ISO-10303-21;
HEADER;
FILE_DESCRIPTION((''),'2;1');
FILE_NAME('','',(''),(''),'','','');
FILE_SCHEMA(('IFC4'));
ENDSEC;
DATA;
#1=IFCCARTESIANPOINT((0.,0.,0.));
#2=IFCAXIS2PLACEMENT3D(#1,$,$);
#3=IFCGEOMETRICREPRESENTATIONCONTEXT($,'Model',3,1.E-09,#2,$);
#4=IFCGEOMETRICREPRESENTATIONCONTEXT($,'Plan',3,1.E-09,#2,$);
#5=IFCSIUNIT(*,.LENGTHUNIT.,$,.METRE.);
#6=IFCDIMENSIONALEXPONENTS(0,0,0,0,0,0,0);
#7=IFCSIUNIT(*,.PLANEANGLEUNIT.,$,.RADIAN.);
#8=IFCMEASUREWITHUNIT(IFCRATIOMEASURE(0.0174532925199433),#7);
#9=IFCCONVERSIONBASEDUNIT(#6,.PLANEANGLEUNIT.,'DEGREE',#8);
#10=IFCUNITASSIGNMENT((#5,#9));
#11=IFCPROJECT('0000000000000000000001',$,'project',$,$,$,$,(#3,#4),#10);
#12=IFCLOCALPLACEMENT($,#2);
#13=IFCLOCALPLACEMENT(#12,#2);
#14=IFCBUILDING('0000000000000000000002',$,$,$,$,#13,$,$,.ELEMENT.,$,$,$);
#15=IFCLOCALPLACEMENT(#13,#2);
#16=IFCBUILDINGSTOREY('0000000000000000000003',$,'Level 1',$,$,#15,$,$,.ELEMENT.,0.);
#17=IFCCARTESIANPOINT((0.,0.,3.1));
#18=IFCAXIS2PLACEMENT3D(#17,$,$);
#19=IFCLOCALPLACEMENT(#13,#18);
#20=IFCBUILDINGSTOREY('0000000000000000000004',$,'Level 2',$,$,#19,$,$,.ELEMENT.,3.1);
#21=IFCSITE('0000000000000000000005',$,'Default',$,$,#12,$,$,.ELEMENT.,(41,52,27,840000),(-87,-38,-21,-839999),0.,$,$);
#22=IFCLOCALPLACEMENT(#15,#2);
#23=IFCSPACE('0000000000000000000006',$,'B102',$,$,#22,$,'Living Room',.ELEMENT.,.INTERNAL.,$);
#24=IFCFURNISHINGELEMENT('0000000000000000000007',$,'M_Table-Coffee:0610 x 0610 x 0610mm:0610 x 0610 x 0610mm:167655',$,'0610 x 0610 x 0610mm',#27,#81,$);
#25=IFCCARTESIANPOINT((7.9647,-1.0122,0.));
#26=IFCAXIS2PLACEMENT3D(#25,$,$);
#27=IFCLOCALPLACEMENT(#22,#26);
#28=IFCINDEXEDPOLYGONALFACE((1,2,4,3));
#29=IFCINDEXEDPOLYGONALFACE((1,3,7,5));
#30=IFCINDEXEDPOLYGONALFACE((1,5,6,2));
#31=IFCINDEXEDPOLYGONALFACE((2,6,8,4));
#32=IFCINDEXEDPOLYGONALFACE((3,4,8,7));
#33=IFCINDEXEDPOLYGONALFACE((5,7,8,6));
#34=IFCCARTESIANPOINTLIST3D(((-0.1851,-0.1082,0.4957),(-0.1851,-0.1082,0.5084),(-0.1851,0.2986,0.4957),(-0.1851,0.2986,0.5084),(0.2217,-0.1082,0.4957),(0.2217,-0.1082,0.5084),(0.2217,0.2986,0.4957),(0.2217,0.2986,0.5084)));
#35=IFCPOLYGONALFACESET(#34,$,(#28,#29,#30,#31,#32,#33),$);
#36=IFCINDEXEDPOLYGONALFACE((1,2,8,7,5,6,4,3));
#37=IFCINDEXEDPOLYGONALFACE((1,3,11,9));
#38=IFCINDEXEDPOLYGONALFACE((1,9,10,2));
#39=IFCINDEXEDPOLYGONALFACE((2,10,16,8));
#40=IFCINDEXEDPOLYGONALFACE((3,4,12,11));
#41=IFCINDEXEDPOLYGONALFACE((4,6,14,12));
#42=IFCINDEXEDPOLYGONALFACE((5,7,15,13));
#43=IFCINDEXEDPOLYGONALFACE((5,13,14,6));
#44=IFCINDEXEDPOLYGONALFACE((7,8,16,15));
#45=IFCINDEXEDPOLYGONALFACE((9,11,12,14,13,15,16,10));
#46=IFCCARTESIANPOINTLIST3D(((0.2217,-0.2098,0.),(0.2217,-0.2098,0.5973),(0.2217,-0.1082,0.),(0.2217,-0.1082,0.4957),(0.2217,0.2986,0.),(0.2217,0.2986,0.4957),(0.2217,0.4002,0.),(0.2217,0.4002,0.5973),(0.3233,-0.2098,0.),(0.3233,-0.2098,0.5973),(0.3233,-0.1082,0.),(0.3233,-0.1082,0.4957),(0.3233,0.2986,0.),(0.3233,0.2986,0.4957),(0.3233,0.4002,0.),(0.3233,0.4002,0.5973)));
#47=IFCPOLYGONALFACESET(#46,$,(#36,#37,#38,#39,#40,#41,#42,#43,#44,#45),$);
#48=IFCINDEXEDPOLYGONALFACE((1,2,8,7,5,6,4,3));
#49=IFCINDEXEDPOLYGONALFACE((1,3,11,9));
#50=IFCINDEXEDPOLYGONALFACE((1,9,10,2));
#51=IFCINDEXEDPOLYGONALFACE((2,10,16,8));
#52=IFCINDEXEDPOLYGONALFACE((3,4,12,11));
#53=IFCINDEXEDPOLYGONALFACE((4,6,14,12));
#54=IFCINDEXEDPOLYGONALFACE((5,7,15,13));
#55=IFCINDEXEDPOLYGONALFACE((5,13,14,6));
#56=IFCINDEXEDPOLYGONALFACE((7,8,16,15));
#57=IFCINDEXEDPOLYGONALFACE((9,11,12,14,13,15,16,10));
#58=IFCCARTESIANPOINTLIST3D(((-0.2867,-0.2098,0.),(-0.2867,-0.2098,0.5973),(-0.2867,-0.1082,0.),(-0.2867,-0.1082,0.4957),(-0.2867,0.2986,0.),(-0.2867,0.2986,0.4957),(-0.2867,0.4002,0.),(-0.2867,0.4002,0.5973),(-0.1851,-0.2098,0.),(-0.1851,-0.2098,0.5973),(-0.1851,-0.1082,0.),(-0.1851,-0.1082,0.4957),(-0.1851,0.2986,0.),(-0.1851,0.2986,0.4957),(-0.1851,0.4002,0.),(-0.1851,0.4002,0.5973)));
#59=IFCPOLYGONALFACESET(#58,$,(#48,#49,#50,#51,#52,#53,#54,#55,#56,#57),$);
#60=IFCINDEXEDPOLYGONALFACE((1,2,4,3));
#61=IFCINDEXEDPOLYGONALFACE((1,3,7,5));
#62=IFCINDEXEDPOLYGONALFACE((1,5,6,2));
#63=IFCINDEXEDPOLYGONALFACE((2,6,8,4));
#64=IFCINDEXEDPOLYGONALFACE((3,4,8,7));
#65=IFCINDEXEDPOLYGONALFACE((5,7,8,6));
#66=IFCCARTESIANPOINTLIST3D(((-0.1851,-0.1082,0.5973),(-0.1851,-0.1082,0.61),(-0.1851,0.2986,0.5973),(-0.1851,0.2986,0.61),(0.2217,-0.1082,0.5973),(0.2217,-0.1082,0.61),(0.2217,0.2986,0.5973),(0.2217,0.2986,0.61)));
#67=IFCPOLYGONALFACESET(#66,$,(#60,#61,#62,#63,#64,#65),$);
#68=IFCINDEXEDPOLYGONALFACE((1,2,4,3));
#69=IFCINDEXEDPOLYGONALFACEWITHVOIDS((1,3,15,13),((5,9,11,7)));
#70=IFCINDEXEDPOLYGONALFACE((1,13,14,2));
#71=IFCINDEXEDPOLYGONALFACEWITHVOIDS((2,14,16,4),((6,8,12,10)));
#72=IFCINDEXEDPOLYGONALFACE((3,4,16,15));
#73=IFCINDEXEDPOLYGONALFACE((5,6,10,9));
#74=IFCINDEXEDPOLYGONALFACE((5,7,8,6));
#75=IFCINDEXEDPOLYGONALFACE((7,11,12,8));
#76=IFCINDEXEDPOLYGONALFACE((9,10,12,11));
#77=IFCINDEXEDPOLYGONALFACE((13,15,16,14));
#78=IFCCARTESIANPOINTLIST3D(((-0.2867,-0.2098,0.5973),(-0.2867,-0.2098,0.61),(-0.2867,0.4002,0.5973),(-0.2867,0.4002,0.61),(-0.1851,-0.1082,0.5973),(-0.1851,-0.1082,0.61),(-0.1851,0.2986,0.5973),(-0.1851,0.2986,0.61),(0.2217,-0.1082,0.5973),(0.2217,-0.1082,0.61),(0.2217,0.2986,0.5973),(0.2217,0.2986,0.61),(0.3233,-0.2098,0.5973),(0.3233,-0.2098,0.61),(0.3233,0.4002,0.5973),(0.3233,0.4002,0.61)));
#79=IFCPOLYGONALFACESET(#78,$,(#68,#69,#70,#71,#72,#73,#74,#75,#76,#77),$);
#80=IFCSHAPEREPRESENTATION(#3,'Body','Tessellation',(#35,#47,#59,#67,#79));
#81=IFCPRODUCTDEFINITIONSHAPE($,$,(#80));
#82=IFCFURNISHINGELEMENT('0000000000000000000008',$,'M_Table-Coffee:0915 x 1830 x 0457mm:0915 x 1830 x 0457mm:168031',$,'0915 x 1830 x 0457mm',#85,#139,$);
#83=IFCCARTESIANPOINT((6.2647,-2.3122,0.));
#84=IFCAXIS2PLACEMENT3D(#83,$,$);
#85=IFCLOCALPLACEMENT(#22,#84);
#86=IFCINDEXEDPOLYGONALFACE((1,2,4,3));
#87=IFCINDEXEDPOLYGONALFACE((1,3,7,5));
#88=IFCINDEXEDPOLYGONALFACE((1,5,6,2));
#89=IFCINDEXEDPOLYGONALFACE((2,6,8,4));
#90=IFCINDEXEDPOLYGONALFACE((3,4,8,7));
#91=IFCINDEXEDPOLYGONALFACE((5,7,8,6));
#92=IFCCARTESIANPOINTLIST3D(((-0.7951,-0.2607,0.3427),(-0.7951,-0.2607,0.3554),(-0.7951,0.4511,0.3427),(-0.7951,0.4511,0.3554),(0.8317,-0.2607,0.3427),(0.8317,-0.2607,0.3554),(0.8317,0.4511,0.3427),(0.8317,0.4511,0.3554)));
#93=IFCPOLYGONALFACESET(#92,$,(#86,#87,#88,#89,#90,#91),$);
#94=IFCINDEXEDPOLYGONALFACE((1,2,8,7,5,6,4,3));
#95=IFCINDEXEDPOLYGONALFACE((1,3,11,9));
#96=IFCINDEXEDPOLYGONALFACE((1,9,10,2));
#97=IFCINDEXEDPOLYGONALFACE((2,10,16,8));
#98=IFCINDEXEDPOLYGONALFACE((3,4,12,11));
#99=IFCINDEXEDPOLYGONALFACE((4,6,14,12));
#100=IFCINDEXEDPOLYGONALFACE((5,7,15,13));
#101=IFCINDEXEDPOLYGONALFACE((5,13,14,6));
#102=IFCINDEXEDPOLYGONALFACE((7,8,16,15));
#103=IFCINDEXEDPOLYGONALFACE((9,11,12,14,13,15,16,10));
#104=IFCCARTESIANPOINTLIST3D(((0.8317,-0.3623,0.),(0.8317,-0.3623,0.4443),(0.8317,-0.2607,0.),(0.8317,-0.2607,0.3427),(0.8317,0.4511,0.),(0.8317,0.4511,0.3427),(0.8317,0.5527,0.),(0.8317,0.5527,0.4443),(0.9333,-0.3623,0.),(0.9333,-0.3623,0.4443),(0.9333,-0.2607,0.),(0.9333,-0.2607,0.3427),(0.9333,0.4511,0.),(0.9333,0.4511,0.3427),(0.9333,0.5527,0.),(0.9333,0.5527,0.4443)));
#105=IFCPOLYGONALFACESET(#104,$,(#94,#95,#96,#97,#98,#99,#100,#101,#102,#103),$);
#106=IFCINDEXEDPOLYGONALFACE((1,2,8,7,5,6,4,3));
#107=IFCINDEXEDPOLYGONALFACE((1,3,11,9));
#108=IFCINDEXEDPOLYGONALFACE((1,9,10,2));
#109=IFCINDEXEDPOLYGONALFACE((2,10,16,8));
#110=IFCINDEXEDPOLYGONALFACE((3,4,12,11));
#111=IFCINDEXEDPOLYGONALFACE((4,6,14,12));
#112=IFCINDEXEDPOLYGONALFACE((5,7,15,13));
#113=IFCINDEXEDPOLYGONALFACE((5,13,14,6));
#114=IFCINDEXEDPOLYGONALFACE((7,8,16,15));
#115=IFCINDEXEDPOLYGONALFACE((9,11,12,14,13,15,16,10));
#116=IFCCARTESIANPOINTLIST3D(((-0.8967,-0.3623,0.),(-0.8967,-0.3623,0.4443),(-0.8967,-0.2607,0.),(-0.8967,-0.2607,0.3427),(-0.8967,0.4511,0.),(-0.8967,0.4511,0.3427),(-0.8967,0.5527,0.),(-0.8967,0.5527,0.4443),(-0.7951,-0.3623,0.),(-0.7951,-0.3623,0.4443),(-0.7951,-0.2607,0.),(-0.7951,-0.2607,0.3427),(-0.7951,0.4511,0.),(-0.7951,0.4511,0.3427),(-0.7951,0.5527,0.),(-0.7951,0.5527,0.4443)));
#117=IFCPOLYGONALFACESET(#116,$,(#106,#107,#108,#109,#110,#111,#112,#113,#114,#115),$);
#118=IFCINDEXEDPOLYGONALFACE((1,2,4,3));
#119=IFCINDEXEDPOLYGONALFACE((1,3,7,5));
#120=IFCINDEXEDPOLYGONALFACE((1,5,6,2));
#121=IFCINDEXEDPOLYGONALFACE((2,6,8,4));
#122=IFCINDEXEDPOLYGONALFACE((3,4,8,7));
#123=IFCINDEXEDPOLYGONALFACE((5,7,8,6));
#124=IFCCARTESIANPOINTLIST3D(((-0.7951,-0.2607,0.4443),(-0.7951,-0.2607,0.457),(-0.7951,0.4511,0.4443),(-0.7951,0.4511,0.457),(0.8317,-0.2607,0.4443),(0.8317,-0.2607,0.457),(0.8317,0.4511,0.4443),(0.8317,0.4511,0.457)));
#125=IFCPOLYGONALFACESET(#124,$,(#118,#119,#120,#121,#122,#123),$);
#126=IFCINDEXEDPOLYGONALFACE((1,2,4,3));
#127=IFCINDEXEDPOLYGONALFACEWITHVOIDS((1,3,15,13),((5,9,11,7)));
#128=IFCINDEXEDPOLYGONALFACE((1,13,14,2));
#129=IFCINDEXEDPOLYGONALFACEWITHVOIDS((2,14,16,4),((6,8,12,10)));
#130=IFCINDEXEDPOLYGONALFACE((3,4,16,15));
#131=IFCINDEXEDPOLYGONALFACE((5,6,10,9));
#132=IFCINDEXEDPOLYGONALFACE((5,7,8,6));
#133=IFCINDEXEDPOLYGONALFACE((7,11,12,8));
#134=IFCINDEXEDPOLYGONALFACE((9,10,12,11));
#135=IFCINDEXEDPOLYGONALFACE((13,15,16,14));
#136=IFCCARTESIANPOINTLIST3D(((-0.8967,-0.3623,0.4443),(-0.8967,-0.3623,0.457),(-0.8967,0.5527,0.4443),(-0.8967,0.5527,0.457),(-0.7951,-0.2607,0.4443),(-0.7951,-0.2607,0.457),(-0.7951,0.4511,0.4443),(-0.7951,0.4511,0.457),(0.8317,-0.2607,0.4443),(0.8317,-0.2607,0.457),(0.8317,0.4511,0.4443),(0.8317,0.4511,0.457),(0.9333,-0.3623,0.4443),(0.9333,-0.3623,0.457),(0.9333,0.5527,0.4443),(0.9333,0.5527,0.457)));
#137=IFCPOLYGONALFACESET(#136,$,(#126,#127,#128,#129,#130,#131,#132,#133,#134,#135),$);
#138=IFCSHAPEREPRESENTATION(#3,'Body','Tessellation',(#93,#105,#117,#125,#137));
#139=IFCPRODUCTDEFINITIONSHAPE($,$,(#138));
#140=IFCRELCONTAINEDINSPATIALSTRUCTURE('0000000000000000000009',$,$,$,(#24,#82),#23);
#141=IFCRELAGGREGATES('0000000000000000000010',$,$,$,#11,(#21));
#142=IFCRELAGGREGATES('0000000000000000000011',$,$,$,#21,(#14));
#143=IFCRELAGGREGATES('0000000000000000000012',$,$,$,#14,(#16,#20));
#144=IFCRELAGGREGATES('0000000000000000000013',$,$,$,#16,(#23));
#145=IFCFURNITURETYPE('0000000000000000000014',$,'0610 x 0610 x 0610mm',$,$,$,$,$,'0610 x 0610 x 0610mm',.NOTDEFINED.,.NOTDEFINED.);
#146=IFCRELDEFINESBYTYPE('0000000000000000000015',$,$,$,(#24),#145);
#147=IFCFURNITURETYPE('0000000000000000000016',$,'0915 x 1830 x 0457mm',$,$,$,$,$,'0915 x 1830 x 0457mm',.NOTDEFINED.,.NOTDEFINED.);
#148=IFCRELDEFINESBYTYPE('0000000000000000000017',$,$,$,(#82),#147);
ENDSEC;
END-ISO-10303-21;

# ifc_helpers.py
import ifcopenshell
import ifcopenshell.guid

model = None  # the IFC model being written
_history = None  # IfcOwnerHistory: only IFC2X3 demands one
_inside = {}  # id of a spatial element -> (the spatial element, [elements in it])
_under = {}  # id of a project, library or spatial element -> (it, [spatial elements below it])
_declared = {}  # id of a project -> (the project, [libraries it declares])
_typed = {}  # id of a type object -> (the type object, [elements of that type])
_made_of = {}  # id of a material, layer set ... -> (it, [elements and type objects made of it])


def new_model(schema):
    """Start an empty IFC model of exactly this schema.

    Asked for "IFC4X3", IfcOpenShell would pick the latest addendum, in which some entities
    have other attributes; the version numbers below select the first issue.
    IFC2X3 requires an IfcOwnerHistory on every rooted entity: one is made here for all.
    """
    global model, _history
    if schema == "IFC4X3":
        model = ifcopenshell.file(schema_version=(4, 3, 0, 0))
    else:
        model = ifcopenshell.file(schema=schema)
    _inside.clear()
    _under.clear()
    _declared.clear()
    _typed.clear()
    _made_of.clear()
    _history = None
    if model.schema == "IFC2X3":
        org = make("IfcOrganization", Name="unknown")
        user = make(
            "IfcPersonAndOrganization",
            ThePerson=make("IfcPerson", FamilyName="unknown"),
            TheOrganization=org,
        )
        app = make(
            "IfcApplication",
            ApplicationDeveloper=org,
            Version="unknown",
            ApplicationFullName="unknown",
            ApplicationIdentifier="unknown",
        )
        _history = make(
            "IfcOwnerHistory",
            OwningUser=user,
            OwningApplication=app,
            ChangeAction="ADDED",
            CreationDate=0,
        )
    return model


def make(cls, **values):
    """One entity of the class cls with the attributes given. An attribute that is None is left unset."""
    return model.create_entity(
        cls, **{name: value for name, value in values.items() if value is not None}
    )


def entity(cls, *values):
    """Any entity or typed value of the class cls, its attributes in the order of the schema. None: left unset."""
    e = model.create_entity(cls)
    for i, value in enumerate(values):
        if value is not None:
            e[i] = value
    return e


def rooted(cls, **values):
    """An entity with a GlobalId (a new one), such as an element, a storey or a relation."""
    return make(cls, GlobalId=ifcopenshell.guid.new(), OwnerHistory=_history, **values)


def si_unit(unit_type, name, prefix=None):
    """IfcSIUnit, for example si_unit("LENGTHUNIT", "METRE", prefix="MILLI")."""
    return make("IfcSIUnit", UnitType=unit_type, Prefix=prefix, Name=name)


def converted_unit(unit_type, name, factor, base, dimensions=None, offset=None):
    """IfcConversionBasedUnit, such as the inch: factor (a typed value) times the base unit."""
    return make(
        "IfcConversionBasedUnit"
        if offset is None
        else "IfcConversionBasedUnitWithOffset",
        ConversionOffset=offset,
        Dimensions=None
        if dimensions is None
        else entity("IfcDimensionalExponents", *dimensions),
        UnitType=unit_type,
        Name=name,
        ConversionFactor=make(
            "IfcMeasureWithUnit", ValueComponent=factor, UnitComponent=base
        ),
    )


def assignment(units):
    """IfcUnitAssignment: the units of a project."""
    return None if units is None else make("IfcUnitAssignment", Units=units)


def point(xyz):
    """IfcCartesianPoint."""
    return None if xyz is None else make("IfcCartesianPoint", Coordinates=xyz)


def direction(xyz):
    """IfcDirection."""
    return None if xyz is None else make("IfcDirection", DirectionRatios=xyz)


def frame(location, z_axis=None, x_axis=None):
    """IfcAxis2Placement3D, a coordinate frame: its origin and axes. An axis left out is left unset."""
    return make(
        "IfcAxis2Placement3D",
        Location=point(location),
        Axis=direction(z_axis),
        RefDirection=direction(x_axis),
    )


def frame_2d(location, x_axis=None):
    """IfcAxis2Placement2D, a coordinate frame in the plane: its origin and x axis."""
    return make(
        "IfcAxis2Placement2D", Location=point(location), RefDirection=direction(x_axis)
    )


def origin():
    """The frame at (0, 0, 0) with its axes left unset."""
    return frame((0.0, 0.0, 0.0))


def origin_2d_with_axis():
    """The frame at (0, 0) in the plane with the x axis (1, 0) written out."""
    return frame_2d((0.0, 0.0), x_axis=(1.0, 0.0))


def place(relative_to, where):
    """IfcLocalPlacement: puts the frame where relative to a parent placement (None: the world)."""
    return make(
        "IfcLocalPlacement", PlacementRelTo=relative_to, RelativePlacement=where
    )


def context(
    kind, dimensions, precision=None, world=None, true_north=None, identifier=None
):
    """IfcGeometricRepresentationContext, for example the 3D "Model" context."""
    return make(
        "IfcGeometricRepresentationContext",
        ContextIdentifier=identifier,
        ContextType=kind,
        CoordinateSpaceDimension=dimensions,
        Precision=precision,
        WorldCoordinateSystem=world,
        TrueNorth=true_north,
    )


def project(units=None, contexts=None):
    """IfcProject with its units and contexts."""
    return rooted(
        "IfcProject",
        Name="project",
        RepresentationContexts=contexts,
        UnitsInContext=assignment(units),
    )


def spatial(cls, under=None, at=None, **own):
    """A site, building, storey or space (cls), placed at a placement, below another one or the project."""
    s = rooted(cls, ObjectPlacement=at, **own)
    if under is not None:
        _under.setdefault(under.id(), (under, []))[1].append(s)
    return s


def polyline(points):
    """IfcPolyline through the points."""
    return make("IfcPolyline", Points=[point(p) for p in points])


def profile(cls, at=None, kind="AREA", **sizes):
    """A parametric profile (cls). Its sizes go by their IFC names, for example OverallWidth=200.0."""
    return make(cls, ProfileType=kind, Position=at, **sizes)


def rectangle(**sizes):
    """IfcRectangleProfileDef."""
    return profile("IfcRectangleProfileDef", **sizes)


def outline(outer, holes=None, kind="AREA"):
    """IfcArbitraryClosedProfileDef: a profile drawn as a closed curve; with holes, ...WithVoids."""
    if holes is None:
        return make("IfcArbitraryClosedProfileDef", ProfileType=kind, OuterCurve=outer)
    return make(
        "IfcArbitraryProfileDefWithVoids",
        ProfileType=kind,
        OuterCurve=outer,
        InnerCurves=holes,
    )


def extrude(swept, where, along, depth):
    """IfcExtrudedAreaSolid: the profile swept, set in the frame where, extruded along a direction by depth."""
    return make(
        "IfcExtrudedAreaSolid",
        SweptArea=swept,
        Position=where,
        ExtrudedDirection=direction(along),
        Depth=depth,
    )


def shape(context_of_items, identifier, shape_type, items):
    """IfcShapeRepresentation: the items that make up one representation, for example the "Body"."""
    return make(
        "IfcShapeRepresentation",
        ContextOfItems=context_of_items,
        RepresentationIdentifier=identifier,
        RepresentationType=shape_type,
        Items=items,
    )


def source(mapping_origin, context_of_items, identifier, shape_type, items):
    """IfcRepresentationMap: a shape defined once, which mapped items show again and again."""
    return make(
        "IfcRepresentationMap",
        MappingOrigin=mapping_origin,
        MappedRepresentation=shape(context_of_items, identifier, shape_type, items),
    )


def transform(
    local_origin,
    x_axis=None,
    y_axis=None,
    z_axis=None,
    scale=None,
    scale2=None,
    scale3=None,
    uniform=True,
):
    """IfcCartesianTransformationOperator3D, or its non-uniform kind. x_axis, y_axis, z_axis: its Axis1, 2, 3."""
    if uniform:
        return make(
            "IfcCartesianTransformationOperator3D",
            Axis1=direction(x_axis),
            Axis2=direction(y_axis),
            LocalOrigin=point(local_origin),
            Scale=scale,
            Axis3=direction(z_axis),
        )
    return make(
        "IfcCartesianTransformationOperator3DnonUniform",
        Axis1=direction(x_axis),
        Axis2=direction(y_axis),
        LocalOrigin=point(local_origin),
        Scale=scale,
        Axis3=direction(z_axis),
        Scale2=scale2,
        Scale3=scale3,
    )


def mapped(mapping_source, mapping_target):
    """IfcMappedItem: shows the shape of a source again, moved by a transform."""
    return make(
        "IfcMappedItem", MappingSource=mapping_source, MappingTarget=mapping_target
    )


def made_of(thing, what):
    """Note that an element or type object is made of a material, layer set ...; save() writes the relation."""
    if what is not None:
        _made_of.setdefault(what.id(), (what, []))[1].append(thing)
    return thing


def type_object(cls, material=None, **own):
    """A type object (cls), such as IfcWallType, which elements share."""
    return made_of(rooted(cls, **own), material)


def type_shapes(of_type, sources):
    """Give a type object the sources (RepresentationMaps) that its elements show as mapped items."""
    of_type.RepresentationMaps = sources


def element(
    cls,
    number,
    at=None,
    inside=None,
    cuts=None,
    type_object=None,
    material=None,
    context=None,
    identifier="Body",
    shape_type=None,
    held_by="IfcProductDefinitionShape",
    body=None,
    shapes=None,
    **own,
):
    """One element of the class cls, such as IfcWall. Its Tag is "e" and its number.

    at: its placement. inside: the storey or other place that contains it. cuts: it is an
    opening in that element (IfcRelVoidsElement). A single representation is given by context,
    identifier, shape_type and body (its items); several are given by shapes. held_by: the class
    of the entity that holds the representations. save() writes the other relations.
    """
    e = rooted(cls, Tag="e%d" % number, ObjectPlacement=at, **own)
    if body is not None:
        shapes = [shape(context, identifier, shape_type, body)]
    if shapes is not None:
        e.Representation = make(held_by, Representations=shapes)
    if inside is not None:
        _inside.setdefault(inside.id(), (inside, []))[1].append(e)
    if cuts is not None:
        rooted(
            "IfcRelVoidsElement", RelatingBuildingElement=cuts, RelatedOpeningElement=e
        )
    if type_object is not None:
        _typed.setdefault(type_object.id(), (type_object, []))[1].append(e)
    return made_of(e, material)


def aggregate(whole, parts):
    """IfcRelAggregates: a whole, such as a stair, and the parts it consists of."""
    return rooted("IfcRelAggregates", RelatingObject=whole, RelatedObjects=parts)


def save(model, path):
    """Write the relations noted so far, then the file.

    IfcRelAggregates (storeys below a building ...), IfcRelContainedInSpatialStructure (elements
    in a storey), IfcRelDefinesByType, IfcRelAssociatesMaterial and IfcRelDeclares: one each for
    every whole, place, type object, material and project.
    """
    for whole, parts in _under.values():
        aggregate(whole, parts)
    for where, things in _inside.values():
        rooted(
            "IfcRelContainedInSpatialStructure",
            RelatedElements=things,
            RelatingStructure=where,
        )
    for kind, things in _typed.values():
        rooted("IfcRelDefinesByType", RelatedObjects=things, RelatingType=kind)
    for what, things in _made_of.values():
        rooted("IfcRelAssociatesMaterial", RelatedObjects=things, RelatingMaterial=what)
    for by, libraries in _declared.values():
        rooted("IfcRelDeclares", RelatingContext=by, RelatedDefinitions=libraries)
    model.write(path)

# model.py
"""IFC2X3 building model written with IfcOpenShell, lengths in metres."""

from ifc_helpers import new_model, entity, si_unit, converted_unit, frame, origin, origin_2d_with_axis, place, context, project, spatial, polyline, rectangle, outline, extrude, source, transform, mapped, type_object, type_shapes, element, save


model = new_model("IFC2X3")

# Units and contexts
model_context = context("Model", 3, precision=1e-09, world=origin())
plan_context = context("Plan", 3, precision=1e-09, world=origin())
ifc_project = project(units=[si_unit("LENGTHUNIT", "METRE"), converted_unit("PLANEANGLEUNIT", "DEGREE", entity("IfcRatioMeasure", 0.0174532925199433), si_unit("PLANEANGLEUNIT", "RADIAN"), dimensions=[0, 0, 0, 0, 0, 0, 0])], contexts=[model_context, plan_context])

# Site, building, storey
site_placement = place(None, origin())
site = spatial("IfcSite", under=ifc_project, at=site_placement, Name="Default", CompositionType="ELEMENT", RefLatitude=(41, 52, 27, 840000), RefLongitude=(-87, -38, -21, -839999), RefElevation=0.0)
building_placement = place(site_placement, origin())
building = spatial("IfcBuilding", under=site, at=building_placement, CompositionType="ELEMENT")
storey_1_placement = place(building_placement, origin())
storey_1 = spatial("IfcBuildingStorey", under=building, at=storey_1_placement, Name="Level 1", CompositionType="ELEMENT", Elevation=0.0)

# Shared definitions
storey_2_placement = place(building_placement, frame((0.0, 0.0, 3.1)))
storey_2 = spatial("IfcBuildingStorey", under=building, at=storey_2_placement, Name="Level 2", CompositionType="ELEMENT", Elevation=3.1)

# Shared definitions
space_1_placement = place(storey_1_placement, origin())
space_1 = spatial("IfcSpace", under=storey_1, at=space_1_placement, Name="B102", LongName="Living Room", CompositionType="ELEMENT", InteriorOrExteriorSpace="INTERNAL")

# Furnishing element
furniture_type_1 = type_object("IfcFurnitureType", Name="0610 x 0610 x 0610mm", ElementType="0610 x 0610 x 0610mm", AssemblyPlace="NOTDEFINED")
shared_shape_1 = source(origin(), model_context, "Body", "SweptSolid", [
    extrude(rectangle(XDim=0.4068, YDim=0.4068, at=origin_2d_with_axis()), frame((0.0183, 0.0952, 0.4957), z_axis=(0.0, 0.0, 1.0), x_axis=(-1.0, 0.0, 0.0)), (0.0, 0.0, 1.0), 0.0127),
    extrude(outline(polyline([(-0.2732, -0.305), (0.324, -0.305), (0.324, 0.305), (-0.2732, 0.305), (-0.2732, 0.2034), (0.2225, 0.2034), (0.2225, -0.2034), (-0.2732, -0.2034), (-0.2732, -0.305)])), frame((0.2217, 0.0952, 0.2732), z_axis=(1.0, 0.0, 0.0), x_axis=(0.0, 0.0, 1.0)), (0.0, 0.0, 1.0), 0.1016),
    extrude(outline(polyline([(-0.305, -0.3241), (0.305, -0.3241), (0.305, 0.2733), (0.2034, 0.2733), (0.2034, -0.2224), (-0.2034, -0.2224), (-0.2034, 0.2733), (-0.305, 0.2733), (-0.305, -0.3241)])), frame((-0.2867, 0.0952, 0.2733), z_axis=(1.0, 0.0, 0.0), x_axis=(0.0, -1.0, 0.0)), (0.0, 0.0, 1.0), 0.1016),
    extrude(rectangle(XDim=0.4068, YDim=0.4068, at=origin_2d_with_axis()), frame((0.0183, 0.0952, 0.5973), z_axis=(0.0, 0.0, 1.0), x_axis=(-1.0, 0.0, 0.0)), (0.0, 0.0, 1.0), 0.0127),
    extrude(outline(polyline([(-0.305, -0.305), (0.305, -0.305), (0.305, 0.305), (-0.305, 0.305), (-0.305, -0.305)]), holes=[polyline([(-0.2034, -0.2034), (-0.2034, 0.2034), (0.2034, 0.2034), (0.2034, -0.2034), (-0.2034, -0.2034)])]), frame((0.0183, 0.0952, 0.5973), z_axis=(0.0, 0.0, 1.0), x_axis=(-1.0, 0.0, 0.0)), (0.0, 0.0, 1.0), 0.0127),
])
type_shapes(furniture_type_1, [shared_shape_1])
for number, where, name in (
    (1, (7.9647, -1.0122, 0.0), "M_Table-Coffee:0610 x 0610 x 0610mm:0610 x 0610 x 0610mm:167655"),
):
    element("IfcFurnishingElement", number, at=place(space_1_placement, frame(where)), inside=space_1, type_object=furniture_type_1, Name=name, ObjectType="0610 x 0610 x 0610mm", context=model_context, shape_type="MappedRepresentation", body=[
        mapped(shared_shape_1, transform((0.0, 0.0, 0.0), scale=1.0)),
    ])

# Furnishing element
furniture_type_2 = type_object("IfcFurnitureType", Name="0915 x 1830 x 0457mm", ElementType="0915 x 1830 x 0457mm", AssemblyPlace="NOTDEFINED")
shared_shape_2 = source(origin(), model_context, "Body", "SweptSolid", [
    extrude(rectangle(XDim=1.6268, YDim=0.7118, at=origin_2d_with_axis()), frame((0.0183, 0.0952, 0.3427), z_axis=(0.0, 0.0, 1.0), x_axis=(-1.0, 0.0, 0.0)), (0.0, 0.0, 1.0), 0.0127),
    extrude(outline(polyline([(-0.1967, -0.4575), (0.2475, -0.4575), (0.2475, 0.4575), (-0.1967, 0.4575), (-0.1967, 0.3559), (0.146, 0.3559), (0.146, -0.3559), (-0.1967, -0.3559), (-0.1967, -0.4575)])), frame((0.8317, 0.0952, 0.1967), z_axis=(1.0, 0.0, 0.0), x_axis=(0.0, 0.0, 1.0)), (0.0, 0.0, 1.0), 0.1016),
    extrude(outline(polyline([(-0.4575, -0.2476), (0.4575, -0.2476), (0.4575, 0.1968), (0.3559, 0.1968), (0.3559, -0.1459), (-0.3559, -0.1459), (-0.3559, 0.1968), (-0.4575, 0.1968), (-0.4575, -0.2476)])), frame((-0.8967, 0.0952, 0.1968), z_axis=(1.0, 0.0, 0.0), x_axis=(0.0, -1.0, 0.0)), (0.0, 0.0, 1.0), 0.1016),
    extrude(rectangle(XDim=1.6268, YDim=0.7118, at=origin_2d_with_axis()), frame((0.0183, 0.0952, 0.4443), z_axis=(0.0, 0.0, 1.0), x_axis=(-1.0, 0.0, 0.0)), (0.0, 0.0, 1.0), 0.0127),
    extrude(outline(polyline([(-0.915, -0.4575), (0.915, -0.4575), (0.915, 0.4575), (-0.915, 0.4575), (-0.915, -0.4575)]), holes=[polyline([(-0.8134, -0.3559), (-0.8134, 0.3559), (0.8134, 0.3559), (0.8134, -0.3559), (-0.8134, -0.3559)])]), frame((0.0183, 0.0952, 0.4443), z_axis=(0.0, 0.0, 1.0), x_axis=(-1.0, 0.0, 0.0)), (0.0, 0.0, 1.0), 0.0127),
])
type_shapes(furniture_type_2, [shared_shape_2])
furnishing_1_placement = place(space_1_placement, frame((6.2647, -2.3122, 0.0)))
element("IfcFurnishingElement", 2, at=furnishing_1_placement, inside=space_1, type_object=furniture_type_2, Name="M_Table-Coffee:0915 x 1830 x 0457mm:0915 x 1830 x 0457mm:168031", ObjectType="0915 x 1830 x 0457mm", context=model_context, shape_type="MappedRepresentation", body=[
    mapped(shared_shape_2, transform((0.0, 0.0, 0.0), scale=1.0)),
])

save(model, "model.ifc")
